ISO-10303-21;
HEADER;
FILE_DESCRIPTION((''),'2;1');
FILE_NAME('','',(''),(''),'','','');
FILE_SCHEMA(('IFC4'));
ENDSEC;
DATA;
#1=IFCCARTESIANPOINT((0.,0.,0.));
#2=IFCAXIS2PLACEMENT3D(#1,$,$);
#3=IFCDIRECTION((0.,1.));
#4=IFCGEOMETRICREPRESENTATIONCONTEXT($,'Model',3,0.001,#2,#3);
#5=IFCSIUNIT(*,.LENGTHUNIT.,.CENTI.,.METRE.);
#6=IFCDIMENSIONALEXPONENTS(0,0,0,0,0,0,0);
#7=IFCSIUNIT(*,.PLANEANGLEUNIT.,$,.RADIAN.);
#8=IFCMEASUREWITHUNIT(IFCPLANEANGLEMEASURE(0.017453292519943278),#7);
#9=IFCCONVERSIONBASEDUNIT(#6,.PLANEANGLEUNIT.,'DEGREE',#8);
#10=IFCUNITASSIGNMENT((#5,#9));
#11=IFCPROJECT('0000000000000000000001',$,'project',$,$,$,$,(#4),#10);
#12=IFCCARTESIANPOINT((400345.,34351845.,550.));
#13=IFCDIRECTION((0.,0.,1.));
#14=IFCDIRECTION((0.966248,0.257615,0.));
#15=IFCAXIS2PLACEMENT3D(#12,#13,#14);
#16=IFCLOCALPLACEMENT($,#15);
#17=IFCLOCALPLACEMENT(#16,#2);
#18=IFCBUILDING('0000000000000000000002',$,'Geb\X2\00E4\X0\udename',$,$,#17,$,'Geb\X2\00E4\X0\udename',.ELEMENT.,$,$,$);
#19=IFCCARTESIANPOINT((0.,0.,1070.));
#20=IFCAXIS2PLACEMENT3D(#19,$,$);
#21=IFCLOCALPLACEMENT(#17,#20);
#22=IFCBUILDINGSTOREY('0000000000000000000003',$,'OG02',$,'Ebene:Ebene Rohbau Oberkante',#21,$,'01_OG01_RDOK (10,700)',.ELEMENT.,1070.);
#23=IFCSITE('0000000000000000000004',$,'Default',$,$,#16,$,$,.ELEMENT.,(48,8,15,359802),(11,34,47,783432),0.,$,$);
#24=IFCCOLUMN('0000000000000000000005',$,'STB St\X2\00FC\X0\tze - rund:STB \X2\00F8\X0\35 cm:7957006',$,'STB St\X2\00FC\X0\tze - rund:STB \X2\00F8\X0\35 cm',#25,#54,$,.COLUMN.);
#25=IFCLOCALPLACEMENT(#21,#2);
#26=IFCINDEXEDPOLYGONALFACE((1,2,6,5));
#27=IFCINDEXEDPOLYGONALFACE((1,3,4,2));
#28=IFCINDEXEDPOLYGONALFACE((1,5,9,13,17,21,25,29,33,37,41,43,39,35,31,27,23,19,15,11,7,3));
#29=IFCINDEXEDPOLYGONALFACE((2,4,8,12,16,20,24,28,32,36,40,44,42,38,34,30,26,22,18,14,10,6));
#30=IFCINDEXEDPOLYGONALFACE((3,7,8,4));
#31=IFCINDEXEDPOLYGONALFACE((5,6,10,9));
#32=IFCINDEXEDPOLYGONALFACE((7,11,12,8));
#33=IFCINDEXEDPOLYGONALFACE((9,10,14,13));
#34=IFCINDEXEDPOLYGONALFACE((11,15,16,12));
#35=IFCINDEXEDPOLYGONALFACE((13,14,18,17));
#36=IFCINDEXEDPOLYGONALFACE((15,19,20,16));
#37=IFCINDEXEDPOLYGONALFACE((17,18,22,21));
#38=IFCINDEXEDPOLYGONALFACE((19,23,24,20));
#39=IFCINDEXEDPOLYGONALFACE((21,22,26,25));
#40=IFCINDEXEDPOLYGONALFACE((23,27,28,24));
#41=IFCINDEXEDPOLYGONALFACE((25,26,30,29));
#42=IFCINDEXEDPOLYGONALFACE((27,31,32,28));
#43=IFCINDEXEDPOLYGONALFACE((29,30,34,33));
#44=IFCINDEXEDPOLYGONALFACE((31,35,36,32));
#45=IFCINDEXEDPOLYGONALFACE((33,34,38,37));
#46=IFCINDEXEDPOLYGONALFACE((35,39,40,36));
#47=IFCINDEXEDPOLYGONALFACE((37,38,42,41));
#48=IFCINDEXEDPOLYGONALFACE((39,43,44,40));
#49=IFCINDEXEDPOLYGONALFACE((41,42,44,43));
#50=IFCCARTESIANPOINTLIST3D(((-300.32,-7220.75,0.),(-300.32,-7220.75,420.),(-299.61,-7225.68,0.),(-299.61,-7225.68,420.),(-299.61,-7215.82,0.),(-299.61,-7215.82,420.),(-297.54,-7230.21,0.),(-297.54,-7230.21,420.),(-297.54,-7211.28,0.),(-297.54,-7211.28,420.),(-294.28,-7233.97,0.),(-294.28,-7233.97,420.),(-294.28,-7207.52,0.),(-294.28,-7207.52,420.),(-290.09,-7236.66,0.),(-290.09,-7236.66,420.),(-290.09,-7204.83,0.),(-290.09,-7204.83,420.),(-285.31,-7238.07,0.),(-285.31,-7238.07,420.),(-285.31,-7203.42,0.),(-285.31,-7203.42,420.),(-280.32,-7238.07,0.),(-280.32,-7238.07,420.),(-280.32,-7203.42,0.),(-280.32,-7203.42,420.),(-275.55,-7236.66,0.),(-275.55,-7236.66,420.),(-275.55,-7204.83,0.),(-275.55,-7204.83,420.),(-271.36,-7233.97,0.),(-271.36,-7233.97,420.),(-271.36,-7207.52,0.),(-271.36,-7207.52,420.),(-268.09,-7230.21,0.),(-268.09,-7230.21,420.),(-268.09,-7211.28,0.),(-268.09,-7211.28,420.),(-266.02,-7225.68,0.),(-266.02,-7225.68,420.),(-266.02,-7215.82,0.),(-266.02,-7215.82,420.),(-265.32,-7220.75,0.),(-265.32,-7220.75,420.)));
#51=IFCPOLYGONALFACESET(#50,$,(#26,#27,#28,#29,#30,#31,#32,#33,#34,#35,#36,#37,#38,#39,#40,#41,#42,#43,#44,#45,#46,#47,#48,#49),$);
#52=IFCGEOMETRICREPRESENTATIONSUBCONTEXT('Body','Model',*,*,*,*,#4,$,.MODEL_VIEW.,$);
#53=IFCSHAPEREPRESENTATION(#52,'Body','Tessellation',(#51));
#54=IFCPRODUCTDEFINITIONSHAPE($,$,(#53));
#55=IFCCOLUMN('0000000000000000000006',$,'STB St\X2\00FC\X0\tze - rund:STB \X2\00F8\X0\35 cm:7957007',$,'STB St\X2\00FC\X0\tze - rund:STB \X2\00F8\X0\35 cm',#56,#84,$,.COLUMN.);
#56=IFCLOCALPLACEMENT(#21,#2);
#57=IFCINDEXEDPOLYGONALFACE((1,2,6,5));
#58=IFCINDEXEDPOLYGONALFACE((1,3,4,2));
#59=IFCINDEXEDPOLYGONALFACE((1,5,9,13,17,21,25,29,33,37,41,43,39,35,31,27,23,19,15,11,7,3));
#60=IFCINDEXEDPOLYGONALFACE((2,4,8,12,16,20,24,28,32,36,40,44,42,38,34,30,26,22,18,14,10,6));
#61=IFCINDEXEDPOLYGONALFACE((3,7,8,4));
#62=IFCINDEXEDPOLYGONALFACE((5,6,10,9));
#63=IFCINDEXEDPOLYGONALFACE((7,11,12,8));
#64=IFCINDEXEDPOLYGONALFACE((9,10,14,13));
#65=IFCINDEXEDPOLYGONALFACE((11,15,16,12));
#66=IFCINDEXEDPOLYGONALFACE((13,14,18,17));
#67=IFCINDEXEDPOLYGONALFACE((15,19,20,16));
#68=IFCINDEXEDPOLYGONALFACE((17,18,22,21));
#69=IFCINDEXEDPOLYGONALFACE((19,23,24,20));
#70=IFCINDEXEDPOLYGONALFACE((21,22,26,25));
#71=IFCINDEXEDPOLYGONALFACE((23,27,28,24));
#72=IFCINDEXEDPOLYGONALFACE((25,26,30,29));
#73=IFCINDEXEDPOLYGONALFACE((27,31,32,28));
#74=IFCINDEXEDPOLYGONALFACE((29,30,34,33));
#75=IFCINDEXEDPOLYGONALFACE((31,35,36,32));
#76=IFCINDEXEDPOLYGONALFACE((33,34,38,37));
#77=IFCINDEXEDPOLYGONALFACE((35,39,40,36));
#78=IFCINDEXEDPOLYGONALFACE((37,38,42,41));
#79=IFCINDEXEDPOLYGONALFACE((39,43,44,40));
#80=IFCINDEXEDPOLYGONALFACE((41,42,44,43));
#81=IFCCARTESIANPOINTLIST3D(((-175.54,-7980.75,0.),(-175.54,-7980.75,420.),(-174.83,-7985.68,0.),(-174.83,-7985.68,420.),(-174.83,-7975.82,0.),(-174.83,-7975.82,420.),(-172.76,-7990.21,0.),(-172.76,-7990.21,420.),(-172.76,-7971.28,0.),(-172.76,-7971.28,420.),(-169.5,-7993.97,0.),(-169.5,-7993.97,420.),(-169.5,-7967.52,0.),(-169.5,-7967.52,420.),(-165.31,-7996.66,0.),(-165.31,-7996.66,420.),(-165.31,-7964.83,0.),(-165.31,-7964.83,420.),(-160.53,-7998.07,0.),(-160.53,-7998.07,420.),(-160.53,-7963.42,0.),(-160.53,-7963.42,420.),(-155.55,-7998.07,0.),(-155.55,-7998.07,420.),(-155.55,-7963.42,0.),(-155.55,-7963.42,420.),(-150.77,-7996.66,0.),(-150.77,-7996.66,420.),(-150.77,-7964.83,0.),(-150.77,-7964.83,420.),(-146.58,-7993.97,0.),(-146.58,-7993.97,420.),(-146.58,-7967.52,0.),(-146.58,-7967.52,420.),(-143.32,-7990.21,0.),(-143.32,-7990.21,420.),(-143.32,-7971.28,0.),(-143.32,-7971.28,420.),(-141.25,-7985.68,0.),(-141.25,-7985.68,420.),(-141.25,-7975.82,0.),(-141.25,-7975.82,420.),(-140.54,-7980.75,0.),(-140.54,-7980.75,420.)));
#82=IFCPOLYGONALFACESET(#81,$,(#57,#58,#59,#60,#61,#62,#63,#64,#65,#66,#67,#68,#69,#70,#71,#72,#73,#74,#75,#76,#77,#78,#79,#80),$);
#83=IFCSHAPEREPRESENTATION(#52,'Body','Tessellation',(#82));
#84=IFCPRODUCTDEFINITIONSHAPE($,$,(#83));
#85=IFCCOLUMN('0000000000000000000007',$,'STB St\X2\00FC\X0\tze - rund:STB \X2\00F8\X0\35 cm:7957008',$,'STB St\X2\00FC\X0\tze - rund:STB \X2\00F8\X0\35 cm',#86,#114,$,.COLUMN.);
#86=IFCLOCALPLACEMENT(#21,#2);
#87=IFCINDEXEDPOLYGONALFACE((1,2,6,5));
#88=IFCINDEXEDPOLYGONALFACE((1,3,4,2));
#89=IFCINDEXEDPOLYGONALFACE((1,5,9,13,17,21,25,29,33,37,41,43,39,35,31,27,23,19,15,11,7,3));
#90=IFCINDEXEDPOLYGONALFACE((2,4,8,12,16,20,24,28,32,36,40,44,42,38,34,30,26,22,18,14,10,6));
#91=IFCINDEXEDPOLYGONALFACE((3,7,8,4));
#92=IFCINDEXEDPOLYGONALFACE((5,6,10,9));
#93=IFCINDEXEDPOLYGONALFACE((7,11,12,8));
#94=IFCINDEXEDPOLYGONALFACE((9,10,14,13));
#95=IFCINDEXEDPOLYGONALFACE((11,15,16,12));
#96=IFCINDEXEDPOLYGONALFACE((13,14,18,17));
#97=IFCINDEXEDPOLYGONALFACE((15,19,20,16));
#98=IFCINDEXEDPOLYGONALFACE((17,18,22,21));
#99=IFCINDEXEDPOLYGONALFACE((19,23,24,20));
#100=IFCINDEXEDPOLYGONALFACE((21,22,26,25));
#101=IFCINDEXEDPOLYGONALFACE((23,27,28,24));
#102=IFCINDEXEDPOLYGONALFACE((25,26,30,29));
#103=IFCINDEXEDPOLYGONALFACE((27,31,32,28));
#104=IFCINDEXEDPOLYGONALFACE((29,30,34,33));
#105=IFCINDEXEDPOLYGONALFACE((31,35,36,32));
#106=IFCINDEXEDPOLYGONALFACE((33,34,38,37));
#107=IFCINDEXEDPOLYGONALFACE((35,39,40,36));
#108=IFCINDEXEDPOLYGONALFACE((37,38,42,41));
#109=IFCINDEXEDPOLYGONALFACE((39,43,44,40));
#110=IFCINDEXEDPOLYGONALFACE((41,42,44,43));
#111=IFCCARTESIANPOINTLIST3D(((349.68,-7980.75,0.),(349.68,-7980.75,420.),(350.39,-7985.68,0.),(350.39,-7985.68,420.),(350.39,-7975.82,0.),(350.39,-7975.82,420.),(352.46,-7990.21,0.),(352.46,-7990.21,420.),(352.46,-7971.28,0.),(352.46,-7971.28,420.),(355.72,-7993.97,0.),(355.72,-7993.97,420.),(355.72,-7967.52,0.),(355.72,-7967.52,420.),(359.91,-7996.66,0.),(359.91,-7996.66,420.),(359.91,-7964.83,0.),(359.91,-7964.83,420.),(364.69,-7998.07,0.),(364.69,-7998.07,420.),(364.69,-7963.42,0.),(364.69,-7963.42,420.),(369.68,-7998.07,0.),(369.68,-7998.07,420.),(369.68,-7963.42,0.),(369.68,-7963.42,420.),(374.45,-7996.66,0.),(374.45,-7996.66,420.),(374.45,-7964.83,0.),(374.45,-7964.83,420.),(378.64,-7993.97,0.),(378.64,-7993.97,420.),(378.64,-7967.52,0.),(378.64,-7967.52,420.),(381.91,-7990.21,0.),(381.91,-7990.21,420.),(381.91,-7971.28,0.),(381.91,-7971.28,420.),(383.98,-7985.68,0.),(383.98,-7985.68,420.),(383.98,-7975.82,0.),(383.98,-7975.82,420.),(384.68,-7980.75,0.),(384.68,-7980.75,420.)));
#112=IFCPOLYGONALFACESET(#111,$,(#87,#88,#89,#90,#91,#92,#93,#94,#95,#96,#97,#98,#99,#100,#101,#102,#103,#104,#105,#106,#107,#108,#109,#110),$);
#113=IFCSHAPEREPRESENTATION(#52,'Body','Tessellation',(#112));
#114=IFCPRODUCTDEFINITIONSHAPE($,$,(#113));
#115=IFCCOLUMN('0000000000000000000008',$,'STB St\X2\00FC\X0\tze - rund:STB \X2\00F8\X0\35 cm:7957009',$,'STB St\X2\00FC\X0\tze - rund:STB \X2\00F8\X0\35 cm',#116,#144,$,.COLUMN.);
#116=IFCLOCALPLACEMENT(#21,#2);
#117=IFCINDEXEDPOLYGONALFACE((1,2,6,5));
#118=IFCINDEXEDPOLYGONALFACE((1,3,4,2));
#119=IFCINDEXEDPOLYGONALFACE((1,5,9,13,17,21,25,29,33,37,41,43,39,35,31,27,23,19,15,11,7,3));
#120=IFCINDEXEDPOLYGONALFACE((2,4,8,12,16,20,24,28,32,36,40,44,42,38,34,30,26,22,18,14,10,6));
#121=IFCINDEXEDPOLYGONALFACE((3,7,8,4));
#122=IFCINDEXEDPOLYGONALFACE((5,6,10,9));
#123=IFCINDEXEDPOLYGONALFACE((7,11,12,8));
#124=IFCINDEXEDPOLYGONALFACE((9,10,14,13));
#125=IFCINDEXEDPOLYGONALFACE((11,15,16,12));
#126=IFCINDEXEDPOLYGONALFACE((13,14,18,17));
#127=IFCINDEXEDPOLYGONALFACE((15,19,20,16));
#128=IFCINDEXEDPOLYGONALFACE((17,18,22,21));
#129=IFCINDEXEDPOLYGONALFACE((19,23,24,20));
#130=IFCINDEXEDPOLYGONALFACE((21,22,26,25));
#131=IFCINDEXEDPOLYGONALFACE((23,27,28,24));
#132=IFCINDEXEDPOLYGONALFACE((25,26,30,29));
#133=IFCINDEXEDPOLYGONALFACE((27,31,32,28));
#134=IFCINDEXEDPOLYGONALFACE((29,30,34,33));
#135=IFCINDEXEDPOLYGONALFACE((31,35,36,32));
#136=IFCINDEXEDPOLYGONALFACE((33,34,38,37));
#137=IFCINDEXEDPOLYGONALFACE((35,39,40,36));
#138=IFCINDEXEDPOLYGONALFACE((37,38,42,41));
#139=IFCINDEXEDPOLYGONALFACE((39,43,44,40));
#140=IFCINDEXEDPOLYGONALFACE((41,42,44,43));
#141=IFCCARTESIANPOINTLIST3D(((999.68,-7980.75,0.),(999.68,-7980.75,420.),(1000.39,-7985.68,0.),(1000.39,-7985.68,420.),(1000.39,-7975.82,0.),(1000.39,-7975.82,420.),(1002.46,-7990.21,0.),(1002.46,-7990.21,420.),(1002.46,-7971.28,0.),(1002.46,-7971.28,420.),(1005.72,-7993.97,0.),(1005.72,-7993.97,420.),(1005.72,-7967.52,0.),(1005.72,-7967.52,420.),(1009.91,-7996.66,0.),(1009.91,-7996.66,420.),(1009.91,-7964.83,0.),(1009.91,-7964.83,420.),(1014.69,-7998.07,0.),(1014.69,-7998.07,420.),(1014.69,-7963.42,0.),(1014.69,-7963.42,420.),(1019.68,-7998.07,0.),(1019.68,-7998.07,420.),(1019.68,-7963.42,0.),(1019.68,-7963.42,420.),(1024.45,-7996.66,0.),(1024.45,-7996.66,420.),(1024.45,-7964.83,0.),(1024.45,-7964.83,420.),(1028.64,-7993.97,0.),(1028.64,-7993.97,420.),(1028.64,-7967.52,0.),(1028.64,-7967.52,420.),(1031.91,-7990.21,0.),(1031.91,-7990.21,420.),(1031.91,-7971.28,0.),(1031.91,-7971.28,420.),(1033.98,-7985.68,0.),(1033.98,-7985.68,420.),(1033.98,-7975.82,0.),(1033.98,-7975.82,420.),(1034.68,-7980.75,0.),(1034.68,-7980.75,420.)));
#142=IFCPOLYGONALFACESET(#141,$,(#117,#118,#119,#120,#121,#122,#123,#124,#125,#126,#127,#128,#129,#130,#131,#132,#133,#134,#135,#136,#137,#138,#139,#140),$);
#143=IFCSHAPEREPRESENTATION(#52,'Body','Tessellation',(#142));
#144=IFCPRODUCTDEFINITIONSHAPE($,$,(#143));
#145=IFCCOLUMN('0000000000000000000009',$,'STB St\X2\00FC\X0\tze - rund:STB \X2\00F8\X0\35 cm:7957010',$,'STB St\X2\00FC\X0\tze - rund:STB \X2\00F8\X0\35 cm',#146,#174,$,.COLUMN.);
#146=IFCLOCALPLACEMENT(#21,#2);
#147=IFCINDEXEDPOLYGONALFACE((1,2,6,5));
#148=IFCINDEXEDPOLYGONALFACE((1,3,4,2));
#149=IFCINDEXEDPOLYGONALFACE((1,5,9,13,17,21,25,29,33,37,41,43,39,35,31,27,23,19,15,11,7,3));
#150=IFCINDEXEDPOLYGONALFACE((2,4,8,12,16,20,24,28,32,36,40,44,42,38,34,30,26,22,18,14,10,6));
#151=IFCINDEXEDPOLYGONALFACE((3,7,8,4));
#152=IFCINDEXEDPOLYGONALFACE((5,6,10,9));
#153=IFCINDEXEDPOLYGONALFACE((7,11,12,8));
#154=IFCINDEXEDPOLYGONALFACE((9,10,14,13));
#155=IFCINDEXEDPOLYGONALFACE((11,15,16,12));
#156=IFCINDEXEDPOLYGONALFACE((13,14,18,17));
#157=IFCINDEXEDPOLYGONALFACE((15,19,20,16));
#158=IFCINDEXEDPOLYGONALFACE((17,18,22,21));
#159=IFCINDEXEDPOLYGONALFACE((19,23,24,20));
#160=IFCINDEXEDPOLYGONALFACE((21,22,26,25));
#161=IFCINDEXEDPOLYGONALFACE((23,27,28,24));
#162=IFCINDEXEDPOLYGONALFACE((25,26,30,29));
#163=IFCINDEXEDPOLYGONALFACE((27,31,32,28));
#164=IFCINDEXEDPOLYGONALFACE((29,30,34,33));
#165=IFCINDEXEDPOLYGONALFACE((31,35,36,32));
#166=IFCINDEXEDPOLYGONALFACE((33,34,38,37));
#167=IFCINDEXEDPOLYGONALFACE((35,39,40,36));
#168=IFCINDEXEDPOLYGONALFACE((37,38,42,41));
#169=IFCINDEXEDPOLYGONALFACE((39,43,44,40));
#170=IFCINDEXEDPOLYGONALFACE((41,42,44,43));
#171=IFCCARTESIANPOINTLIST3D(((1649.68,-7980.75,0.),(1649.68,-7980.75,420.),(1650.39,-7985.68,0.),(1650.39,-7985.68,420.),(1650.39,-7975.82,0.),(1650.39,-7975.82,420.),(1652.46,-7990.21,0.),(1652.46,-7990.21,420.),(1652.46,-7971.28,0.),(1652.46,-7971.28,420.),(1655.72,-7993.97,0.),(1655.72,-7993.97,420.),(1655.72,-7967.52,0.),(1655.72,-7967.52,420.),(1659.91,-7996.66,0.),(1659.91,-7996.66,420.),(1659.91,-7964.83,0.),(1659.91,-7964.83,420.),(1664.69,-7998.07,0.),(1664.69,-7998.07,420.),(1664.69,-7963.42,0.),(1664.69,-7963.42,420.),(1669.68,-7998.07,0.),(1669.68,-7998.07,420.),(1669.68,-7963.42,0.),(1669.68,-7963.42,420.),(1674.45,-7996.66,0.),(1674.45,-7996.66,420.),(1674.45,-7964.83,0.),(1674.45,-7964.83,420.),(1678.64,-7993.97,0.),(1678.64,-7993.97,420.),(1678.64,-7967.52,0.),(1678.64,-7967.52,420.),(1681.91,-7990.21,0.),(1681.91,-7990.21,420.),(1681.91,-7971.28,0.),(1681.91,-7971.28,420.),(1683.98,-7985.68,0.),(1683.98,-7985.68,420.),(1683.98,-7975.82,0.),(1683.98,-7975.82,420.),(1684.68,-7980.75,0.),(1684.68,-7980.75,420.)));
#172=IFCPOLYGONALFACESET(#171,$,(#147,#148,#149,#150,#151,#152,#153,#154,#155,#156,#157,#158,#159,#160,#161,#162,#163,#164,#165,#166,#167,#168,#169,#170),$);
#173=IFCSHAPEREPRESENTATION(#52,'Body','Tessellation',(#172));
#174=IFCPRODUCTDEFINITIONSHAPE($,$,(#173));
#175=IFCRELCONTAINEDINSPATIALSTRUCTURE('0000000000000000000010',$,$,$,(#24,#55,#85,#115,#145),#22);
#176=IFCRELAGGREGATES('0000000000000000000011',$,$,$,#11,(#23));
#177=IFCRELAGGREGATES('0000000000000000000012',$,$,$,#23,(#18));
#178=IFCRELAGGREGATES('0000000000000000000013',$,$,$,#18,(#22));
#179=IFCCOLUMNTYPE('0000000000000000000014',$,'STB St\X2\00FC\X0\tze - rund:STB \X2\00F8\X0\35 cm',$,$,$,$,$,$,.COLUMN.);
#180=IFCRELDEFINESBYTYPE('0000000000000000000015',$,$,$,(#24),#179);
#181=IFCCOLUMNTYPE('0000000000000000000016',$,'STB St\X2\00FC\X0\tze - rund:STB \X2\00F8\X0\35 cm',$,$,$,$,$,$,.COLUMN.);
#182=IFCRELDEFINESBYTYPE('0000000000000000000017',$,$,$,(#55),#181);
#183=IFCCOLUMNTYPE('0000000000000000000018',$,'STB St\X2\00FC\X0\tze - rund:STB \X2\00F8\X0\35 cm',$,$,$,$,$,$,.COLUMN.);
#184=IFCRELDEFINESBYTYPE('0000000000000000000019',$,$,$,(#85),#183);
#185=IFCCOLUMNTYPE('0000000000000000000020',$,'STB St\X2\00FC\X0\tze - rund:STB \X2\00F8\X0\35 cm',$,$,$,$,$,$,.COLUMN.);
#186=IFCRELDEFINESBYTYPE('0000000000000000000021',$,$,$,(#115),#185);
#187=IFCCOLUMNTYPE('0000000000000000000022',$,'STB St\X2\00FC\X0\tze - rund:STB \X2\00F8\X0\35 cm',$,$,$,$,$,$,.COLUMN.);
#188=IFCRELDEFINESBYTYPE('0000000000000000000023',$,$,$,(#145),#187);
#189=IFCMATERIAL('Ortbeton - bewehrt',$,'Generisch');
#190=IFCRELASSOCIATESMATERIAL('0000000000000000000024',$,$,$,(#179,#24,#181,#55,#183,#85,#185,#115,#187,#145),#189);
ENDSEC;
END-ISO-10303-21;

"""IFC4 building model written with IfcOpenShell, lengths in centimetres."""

from ifc_helpers import new_model, entity, si_unit, converted_unit, direction, frame, origin, place, context, subcontext, project, spatial, arc, indexed_curve, outline, extrude, source, transform, mapped, material, type_object, type_shapes, element, save


model = new_model("IFC4")

# Units and contexts
model_context = context("Model", 3, precision=0.001, world=origin(), true_north=direction((0.0, 1.0)))
body_context = subcontext(model_context, "Body", "Model", "MODEL_VIEW")
ifc_project = project(units=[si_unit("LENGTHUNIT", "METRE", prefix="CENTI"), converted_unit("PLANEANGLEUNIT", "DEGREE", entity("IfcPlaneAngleMeasure", 0.017453292519943278), si_unit("PLANEANGLEUNIT", "RADIAN"), dimensions=[0, 0, 0, 0, 0, 0, 0])], contexts=[model_context])

# Site, building, storey
site_placement = place(None, frame((400345.0, 34351845.0, 550.0), z_axis=(0.0, 0.0, 1.0), x_axis=(0.966248, 0.257615, 0.0)))
site = spatial("IfcSite", under=ifc_project, at=site_placement, Name="Default", CompositionType="ELEMENT", RefLatitude=(48, 8, 15, 359802), RefLongitude=(11, 34, 47, 783432), RefElevation=0.0)
building_placement = place(site_placement, origin())
building = spatial("IfcBuilding", under=site, at=building_placement, Name="Gebäudename", LongName="Gebäudename", CompositionType="ELEMENT")
storey_placement = place(building_placement, frame((0.0, 0.0, 1070.0)))
storey = spatial("IfcBuildingStorey", under=building, at=storey_placement, Name="OG02", ObjectType="Ebene:Ebene Rohbau Oberkante", LongName="01_OG01_RDOK (10,700)", CompositionType="ELEMENT", Elevation=1070.0)

# Columns
ifc_material = material(Name="Ortbeton - bewehrt", Category="Generisch")
column_type_1 = type_object("IfcColumnType", Name="STB Stütze - rund:STB ø35 cm", PredefinedType="COLUMN", material=ifc_material)
shared_shape_1 = source(origin(), body_context, "Body", "SweptSolid", [
    extrude(outline(indexed_curve([(-17.5, 0.0), (0.0, -17.5), (17.5, 0.0), (0.0, 17.5)], segments=[arc(1, 2, 3), arc(3, 4, 1)], self_intersect=False)), frame((-282.82, -7220.75, 1070.0)), (0.0, 0.0, 1.0), 420.0),
])
type_shapes(column_type_1, [shared_shape_1])
column_1_placement = place(storey_placement, frame((0.0, 0.0, -1070.0)))
element("IfcColumn", 1, at=column_1_placement, inside=storey, type_object=column_type_1, material=ifc_material, Name="STB Stütze - rund:STB ø35 cm:7957006", ObjectType="STB Stütze - rund:STB ø35 cm", PredefinedType="COLUMN", context=body_context, shape_type="MappedRepresentation", body=[
    mapped(shared_shape_1, transform((0.0, 0.0, 0.0), scale=1.0)),
])
column_type_2 = type_object("IfcColumnType", Name="STB Stütze - rund:STB ø35 cm", PredefinedType="COLUMN", material=ifc_material)
shared_shape_2 = source(origin(), body_context, "Body", "SweptSolid", [
    extrude(outline(indexed_curve([(-17.5, 0.0), (0.0, -17.5), (17.5, 0.0), (0.0, 17.5)], segments=[arc(1, 2, 3), arc(3, 4, 1)], self_intersect=False)), frame((-158.04, -7980.75, 1070.0)), (0.0, 0.0, 1.0), 420.0),
])
type_shapes(column_type_2, [shared_shape_2])
column_2_placement = place(storey_placement, frame((0.0, 0.0, -1070.0)))
element("IfcColumn", 2, at=column_2_placement, inside=storey, type_object=column_type_2, material=ifc_material, Name="STB Stütze - rund:STB ø35 cm:7957007", ObjectType="STB Stütze - rund:STB ø35 cm", PredefinedType="COLUMN", context=body_context, shape_type="MappedRepresentation", body=[
    mapped(shared_shape_2, transform((0.0, 0.0, 0.0), scale=1.0)),
])
column_type_3 = type_object("IfcColumnType", Name="STB Stütze - rund:STB ø35 cm", PredefinedType="COLUMN", material=ifc_material)
shared_shape_3 = source(origin(), body_context, "Body", "SweptSolid", [
    extrude(outline(indexed_curve([(-17.5, 0.0), (0.0, -17.5), (17.5, 0.0), (0.0, 17.5)], segments=[arc(1, 2, 3), arc(3, 4, 1)], self_intersect=False)), frame((367.18, -7980.75, 1070.0)), (0.0, 0.0, 1.0), 420.0),
])
type_shapes(column_type_3, [shared_shape_3])
column_3_placement = place(storey_placement, frame((0.0, 0.0, -1070.0)))
element("IfcColumn", 3, at=column_3_placement, inside=storey, type_object=column_type_3, material=ifc_material, Name="STB Stütze - rund:STB ø35 cm:7957008", ObjectType="STB Stütze - rund:STB ø35 cm", PredefinedType="COLUMN", context=body_context, shape_type="MappedRepresentation", body=[
    mapped(shared_shape_3, transform((0.0, 0.0, 0.0), scale=1.0)),
])
column_type_4 = type_object("IfcColumnType", Name="STB Stütze - rund:STB ø35 cm", PredefinedType="COLUMN", material=ifc_material)
shared_shape_4 = source(origin(), body_context, "Body", "SweptSolid", [
    extrude(outline(indexed_curve([(-17.5, 0.0), (0.0, -17.5), (17.5, 0.0), (0.0, 17.5)], segments=[arc(1, 2, 3), arc(3, 4, 1)], self_intersect=False)), frame((1017.18, -7980.75, 1070.0)), (0.0, 0.0, 1.0), 420.0),
])
type_shapes(column_type_4, [shared_shape_4])
column_4_placement = place(storey_placement, frame((0.0, 0.0, -1070.0)))
element("IfcColumn", 4, at=column_4_placement, inside=storey, type_object=column_type_4, material=ifc_material, Name="STB Stütze - rund:STB ø35 cm:7957009", ObjectType="STB Stütze - rund:STB ø35 cm", PredefinedType="COLUMN", context=body_context, shape_type="MappedRepresentation", body=[
    mapped(shared_shape_4, transform((0.0, 0.0, 0.0), scale=1.0)),
])
column_type_5 = type_object("IfcColumnType", Name="STB Stütze - rund:STB ø35 cm", PredefinedType="COLUMN", material=ifc_material)
shared_shape_5 = source(origin(), body_context, "Body", "SweptSolid", [
    extrude(outline(indexed_curve([(-17.5, 0.0), (0.0, -17.5), (17.5, 0.0), (0.0, 17.5)], segments=[arc(1, 2, 3), arc(3, 4, 1)], self_intersect=False)), frame((1667.18, -7980.75, 1070.0)), (0.0, 0.0, 1.0), 420.0),
])
type_shapes(column_type_5, [shared_shape_5])
column_5_placement = place(storey_placement, frame((0.0, 0.0, -1070.0)))
element("IfcColumn", 5, at=column_5_placement, inside=storey, type_object=column_type_5, material=ifc_material, Name="STB Stütze - rund:STB ø35 cm:7957010", ObjectType="STB Stütze - rund:STB ø35 cm", PredefinedType="COLUMN", context=body_context, shape_type="MappedRepresentation", body=[
    mapped(shared_shape_5, transform((0.0, 0.0, 0.0), scale=1.0)),
])

save(model, "model.ifc")
